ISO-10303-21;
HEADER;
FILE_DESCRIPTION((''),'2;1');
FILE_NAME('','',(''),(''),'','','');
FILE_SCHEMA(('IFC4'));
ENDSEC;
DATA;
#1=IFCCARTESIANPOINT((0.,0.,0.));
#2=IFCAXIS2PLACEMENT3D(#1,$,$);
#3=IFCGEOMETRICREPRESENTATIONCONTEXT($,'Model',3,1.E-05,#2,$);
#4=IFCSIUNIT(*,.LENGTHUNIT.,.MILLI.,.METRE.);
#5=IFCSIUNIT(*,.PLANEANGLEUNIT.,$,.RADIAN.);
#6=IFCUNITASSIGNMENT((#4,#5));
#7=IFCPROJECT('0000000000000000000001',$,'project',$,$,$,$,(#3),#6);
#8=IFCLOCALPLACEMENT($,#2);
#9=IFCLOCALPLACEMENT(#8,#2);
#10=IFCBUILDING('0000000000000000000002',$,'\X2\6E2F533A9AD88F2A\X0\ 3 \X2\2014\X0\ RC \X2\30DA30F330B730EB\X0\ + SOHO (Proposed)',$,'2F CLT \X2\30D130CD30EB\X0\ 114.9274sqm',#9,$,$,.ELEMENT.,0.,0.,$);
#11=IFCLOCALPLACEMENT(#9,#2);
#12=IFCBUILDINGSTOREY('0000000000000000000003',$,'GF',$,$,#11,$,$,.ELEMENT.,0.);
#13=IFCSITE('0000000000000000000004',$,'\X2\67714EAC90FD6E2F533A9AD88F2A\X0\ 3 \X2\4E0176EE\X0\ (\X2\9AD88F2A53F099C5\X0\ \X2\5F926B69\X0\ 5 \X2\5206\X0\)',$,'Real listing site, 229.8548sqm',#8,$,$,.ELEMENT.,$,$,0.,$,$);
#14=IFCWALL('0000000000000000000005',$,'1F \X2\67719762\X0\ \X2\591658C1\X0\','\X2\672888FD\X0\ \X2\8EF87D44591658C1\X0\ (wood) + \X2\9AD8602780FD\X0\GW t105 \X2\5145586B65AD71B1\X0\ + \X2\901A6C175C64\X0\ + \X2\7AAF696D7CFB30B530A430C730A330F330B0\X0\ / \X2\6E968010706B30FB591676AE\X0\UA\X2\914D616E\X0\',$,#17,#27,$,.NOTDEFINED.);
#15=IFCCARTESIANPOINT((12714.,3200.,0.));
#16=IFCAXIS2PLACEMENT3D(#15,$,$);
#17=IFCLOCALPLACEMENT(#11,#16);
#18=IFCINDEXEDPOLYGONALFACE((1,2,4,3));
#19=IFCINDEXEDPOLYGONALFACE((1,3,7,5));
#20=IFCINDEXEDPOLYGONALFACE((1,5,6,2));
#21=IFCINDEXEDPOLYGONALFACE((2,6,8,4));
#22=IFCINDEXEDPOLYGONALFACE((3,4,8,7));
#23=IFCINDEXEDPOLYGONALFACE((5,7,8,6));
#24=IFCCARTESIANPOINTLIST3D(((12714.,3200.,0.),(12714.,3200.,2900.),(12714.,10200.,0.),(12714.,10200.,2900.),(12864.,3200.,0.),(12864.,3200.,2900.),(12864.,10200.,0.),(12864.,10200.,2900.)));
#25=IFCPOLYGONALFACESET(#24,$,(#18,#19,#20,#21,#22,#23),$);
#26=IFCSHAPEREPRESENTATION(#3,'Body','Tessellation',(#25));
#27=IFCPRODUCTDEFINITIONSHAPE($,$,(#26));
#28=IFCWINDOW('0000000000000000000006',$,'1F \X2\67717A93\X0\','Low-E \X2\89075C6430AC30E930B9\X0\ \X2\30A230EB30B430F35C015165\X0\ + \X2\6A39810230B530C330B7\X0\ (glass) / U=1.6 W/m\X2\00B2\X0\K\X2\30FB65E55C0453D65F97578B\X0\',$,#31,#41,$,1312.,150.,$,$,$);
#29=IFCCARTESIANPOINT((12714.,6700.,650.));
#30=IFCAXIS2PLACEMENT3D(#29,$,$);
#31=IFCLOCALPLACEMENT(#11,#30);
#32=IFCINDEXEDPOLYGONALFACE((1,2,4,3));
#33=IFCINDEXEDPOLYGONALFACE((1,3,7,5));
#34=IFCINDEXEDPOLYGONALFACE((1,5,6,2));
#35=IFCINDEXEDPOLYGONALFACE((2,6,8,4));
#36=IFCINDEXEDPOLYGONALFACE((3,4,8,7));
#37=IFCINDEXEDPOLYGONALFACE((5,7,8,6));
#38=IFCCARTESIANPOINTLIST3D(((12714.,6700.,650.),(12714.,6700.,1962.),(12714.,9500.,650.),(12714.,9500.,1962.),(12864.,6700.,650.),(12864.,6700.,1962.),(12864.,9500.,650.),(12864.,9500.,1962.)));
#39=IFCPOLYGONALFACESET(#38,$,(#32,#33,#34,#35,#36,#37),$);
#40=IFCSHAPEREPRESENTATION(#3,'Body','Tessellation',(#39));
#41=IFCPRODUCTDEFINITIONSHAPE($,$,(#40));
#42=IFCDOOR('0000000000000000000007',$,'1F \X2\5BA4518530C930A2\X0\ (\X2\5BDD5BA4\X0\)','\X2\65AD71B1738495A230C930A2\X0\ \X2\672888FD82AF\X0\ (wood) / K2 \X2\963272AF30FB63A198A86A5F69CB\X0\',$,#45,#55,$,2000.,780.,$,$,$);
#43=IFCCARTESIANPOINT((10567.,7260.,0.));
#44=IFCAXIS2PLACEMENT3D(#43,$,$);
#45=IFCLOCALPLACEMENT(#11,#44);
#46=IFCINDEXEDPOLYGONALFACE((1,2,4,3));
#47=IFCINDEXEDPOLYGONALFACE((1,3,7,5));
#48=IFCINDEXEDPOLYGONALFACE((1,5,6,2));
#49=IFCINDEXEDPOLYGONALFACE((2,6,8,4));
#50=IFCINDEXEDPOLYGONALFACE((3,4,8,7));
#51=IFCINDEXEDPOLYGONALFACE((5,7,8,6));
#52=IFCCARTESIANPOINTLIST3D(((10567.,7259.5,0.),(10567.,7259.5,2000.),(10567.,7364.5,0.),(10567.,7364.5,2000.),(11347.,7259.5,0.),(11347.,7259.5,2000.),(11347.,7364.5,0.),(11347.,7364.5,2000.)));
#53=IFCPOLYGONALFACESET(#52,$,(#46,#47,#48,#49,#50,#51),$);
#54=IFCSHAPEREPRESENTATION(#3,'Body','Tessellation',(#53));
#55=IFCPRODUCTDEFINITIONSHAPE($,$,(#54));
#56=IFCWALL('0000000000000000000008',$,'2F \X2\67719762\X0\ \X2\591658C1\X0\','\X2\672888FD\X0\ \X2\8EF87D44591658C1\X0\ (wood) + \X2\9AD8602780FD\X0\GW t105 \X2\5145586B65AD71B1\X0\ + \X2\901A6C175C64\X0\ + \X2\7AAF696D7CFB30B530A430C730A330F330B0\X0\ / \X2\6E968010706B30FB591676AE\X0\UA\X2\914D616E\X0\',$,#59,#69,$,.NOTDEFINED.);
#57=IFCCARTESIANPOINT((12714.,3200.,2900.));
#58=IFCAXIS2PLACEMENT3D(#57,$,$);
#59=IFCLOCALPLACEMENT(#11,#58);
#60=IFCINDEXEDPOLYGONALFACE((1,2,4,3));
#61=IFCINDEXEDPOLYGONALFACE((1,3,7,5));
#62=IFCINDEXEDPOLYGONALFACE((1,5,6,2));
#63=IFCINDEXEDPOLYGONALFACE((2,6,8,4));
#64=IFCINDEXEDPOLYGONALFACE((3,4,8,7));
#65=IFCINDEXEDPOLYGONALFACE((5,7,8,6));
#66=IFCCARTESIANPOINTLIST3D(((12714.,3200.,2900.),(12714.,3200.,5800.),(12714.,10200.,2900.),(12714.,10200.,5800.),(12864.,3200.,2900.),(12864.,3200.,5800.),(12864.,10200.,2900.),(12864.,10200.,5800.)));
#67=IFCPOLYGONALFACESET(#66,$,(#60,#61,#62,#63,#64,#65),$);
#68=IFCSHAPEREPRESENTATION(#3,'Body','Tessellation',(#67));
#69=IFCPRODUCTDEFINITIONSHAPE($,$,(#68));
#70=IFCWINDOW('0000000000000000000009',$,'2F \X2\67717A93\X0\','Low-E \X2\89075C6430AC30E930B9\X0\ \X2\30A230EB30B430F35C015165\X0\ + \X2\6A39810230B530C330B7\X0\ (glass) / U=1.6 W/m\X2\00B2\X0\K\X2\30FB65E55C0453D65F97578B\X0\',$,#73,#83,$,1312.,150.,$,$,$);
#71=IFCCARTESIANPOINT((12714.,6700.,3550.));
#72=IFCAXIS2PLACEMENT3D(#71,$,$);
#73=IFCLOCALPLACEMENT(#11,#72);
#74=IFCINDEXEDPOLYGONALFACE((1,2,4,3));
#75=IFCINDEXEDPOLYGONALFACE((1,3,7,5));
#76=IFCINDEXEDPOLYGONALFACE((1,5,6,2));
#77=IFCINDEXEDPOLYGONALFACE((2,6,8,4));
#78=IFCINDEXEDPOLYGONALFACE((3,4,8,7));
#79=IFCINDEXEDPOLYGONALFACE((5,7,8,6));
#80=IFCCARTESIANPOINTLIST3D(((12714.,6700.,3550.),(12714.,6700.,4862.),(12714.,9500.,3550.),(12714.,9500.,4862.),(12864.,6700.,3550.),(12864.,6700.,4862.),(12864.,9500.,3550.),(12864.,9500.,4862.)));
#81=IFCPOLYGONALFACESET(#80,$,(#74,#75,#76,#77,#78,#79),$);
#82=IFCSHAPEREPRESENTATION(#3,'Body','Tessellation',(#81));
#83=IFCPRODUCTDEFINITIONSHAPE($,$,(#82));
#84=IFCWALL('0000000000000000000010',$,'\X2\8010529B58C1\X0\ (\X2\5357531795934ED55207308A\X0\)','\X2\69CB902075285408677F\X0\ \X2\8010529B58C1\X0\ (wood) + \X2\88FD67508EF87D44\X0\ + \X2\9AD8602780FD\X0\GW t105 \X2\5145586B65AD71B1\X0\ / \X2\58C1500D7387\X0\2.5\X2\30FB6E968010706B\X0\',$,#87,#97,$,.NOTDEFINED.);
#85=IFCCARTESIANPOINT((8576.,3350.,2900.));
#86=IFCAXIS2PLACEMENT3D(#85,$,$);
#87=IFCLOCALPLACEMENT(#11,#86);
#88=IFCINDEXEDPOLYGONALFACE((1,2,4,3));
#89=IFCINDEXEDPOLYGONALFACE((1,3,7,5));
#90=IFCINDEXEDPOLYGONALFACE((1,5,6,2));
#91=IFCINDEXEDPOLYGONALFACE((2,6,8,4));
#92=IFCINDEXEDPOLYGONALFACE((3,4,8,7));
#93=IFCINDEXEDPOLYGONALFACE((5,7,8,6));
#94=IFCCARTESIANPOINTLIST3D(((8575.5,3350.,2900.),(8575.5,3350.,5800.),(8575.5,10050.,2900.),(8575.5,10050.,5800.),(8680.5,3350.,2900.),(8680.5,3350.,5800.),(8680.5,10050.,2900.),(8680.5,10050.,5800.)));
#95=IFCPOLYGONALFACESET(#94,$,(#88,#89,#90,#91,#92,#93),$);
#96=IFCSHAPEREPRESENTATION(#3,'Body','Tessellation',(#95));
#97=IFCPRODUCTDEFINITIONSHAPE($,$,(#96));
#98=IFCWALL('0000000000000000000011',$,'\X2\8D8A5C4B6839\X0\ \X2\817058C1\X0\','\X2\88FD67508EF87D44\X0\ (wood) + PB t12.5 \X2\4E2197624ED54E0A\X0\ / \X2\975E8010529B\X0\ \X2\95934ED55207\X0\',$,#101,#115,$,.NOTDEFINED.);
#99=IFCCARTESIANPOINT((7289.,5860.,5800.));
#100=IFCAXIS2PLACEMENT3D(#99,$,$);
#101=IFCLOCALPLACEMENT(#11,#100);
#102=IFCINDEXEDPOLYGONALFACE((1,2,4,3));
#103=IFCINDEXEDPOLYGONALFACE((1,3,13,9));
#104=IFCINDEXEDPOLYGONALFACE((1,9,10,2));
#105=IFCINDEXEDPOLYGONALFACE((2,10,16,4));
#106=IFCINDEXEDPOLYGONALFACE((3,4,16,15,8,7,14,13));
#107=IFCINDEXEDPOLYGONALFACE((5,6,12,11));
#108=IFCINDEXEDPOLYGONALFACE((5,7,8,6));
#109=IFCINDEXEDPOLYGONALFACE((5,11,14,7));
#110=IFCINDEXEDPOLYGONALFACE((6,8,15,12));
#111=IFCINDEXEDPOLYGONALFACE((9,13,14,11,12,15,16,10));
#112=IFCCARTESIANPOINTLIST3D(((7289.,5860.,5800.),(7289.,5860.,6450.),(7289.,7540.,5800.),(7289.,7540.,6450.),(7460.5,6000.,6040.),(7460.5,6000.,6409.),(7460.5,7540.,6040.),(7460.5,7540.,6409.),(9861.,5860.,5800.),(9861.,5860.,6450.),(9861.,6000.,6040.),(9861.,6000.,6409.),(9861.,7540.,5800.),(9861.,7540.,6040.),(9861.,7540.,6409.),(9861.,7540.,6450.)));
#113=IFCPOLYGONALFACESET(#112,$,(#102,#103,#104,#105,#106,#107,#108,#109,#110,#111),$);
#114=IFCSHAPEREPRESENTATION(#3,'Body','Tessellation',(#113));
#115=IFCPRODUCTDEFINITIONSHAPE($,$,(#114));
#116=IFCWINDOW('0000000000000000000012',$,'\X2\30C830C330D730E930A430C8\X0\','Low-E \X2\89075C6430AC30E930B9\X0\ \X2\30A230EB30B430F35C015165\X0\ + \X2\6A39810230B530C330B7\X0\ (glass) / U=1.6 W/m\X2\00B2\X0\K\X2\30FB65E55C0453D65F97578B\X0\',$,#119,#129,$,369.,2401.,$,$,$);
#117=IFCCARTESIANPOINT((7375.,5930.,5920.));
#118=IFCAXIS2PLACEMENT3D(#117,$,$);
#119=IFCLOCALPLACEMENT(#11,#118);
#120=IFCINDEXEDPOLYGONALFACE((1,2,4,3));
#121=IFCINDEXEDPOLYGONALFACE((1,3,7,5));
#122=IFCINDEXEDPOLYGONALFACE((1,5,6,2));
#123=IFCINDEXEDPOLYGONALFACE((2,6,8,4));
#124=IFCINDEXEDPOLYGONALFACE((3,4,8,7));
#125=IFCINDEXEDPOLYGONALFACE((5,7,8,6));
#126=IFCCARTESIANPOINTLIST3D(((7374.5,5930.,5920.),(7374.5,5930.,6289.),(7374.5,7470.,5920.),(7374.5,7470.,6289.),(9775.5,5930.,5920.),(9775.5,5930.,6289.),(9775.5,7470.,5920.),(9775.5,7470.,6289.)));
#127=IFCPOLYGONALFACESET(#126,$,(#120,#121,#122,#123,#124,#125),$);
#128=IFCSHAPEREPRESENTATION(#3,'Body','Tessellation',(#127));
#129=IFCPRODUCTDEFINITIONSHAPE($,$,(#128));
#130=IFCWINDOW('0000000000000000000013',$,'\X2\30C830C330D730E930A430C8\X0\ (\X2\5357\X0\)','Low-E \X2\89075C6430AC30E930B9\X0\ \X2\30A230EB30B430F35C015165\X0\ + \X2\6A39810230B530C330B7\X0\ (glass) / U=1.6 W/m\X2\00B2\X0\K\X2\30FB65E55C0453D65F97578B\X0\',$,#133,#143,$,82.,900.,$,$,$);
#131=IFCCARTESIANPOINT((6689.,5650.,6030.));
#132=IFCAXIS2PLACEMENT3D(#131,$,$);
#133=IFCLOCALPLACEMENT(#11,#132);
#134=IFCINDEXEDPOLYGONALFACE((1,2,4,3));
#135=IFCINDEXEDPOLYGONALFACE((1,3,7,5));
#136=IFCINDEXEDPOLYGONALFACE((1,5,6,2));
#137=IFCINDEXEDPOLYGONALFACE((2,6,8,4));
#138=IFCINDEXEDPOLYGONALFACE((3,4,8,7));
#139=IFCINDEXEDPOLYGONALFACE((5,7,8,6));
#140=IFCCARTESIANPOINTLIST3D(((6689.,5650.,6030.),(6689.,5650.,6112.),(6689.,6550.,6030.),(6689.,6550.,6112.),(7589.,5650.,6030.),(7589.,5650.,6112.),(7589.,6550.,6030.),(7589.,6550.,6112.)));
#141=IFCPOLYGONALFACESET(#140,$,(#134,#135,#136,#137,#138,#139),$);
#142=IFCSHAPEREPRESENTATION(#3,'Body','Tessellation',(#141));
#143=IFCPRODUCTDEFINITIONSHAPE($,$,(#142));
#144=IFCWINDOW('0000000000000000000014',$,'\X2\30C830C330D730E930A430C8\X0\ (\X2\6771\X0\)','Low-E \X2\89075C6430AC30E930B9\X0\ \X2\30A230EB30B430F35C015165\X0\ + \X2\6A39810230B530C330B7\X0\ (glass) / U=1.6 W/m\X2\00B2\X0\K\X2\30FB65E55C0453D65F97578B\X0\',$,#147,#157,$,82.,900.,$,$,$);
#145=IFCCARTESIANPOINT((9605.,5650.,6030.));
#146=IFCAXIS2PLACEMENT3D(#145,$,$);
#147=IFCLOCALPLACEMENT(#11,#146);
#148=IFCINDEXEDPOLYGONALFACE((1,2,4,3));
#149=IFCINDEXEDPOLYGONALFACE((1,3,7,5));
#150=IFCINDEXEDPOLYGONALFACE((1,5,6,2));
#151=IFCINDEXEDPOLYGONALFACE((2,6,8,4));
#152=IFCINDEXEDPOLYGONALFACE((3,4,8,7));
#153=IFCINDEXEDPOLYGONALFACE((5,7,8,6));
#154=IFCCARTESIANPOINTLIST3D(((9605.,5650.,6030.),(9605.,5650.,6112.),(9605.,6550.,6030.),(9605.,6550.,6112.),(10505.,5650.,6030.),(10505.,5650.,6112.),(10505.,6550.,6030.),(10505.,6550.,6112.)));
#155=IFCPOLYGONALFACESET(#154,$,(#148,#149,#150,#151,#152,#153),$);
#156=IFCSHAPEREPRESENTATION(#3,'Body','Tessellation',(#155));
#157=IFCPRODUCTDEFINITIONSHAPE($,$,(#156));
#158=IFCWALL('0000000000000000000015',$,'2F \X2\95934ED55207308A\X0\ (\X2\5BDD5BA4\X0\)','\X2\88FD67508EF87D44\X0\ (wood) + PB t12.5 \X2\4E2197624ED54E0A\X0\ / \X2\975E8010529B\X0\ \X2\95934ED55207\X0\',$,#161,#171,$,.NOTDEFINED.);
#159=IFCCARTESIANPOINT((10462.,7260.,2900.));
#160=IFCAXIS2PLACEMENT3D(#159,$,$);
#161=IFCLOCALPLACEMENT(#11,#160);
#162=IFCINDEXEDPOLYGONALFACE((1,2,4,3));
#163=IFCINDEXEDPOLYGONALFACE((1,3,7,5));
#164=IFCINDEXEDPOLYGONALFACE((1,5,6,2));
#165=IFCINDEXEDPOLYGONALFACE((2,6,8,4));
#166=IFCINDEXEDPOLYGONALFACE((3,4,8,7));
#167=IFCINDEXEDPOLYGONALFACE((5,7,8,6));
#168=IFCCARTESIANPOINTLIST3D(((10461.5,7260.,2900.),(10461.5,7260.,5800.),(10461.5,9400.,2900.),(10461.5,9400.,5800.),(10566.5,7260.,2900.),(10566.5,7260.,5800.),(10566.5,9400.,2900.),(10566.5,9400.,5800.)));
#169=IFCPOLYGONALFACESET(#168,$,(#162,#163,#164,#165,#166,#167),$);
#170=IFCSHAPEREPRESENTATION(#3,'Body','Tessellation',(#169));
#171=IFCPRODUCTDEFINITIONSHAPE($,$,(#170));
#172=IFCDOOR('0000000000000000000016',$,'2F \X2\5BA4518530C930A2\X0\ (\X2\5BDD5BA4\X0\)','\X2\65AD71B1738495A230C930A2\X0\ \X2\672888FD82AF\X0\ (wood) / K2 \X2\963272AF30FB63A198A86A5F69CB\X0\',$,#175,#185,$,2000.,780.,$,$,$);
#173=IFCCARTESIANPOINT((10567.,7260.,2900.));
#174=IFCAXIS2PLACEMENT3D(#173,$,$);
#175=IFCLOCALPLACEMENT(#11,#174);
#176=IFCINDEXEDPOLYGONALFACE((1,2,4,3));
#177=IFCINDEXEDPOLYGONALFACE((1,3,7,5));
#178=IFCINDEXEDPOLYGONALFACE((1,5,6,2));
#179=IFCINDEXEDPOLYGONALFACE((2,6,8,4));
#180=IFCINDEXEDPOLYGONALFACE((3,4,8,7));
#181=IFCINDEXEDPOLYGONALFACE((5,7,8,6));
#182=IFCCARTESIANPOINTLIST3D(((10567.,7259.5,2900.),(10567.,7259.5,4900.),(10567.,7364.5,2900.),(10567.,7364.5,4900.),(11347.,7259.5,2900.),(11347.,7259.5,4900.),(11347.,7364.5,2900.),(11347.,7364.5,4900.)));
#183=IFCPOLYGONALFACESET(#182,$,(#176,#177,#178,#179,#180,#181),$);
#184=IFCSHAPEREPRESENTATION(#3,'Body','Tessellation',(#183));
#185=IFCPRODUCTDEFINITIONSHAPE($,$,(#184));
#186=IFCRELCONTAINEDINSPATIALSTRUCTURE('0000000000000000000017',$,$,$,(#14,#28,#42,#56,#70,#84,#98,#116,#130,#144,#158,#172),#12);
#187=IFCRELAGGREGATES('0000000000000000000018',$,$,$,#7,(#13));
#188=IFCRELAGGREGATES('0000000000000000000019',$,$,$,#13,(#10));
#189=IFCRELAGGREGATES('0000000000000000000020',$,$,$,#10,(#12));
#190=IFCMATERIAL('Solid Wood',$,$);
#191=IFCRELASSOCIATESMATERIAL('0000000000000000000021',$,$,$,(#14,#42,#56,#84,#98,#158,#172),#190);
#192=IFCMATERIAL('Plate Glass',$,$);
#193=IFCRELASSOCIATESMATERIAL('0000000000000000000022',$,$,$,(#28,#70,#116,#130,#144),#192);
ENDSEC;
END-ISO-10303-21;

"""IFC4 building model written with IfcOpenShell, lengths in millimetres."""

from ifc_helpers import new_model, si_unit, frame, frame_2d, origin, place, context, project, spatial, rectangle, extrude, material, element, fill, save


model = new_model("IFC4")

# Units and contexts
model_context = context("Model", 3, precision=1e-05, world=origin())
ifc_project = project(units=[si_unit("LENGTHUNIT", "METRE", prefix="MILLI"), si_unit("PLANEANGLEUNIT", "RADIAN")], contexts=[model_context])

# Site, building, storey
site_placement = place(None, origin())
site = spatial("IfcSite", under=ifc_project, at=site_placement, Name="東京都港区高輪 3 丁目 (高輪台駅 徒歩 5 分)", ObjectType="Real listing site, 229.8548sqm", CompositionType="ELEMENT", RefElevation=0.0)
building_placement = place(site_placement, origin())
building = spatial("IfcBuilding", under=site, at=building_placement, Name="港区高輪 3 — RC ペンシル + SOHO (Proposed)", ObjectType="2F CLT パネル 114.9274sqm", CompositionType="ELEMENT", ElevationOfRefHeight=0.0, ElevationOfTerrain=0.0)
storey_placement = place(building_placement, origin())
storey = spatial("IfcBuildingStorey", under=building, at=storey_placement, Name="GF", CompositionType="ELEMENT", Elevation=0.0)

# Wall, opening, window
ifc_material_1 = material(Name="Solid Wood")
wall_1_placement = place(storey_placement, frame((12714.0, 3200.0, 0.0)))
wall_1 = element("IfcWall", 1, at=wall_1_placement, inside=storey, material=ifc_material_1, Name="1F 東面 外壁", Description="木製 軸組外壁 (wood) + 高性能GW t105 充填断熱 + 通気層 + 窯業系サイディング / 準耐火・外皮UA配慮", PredefinedType="NOTDEFINED", context=model_context, shape_type="SweptSolid", body=[
    extrude(rectangle(XDim=150.0, YDim=7000.0, at=frame_2d((75.0, 3500.0))), frame((12714.0, 3200.0, 0.0)), (0.0, 0.0, 1.0), 2900.0),
])
opening_1_placement = place(storey_placement, frame((12714.0, 6700.0, 650.0)))
opening_1 = element("IfcOpeningElement", 2, at=opening_1_placement, cuts=wall_1, PredefinedType="NOTDEFINED", context=model_context, shape_type="SweptSolid", body=[
    extrude(rectangle(XDim=150.0, YDim=2800.0, at=frame_2d((75.0, 1400.0))), frame((12714.0, 6700.0, 650.0)), (0.0, 0.0, 1.0), 1312.0),
])
ifc_material_2 = material(Name="Plate Glass")
window_1_placement = place(storey_placement, frame((12714.0, 6700.0, 650.0)))
window_1 = element("IfcWindow", 3, at=window_1_placement, inside=storey, material=ifc_material_2, Name="1F 東窓", Description="Low-E 複層ガラス アルゴン封入 + 樹脂サッシ (glass) / U=1.6 W/m²K・日射取得型", OverallHeight=1312.0, OverallWidth=150.0, context=model_context, shape_type="SweptSolid", body=[
    extrude(rectangle(XDim=150.0, YDim=2800.0, at=frame_2d((75.0, 1400.0))), frame((12714.0, 6700.0, 650.0)), (0.0, 0.0, 1.0), 1312.0),
])
fill(opening_1, window_1)

# Door
door_1_placement = place(storey_placement, frame((10567.0, 7260.0, 0.0)))
element("IfcDoor", 4, at=door_1_placement, inside=storey, material=ifc_material_1, Name="1F 室内ドア (寝室)", Description="断熱玄関ドア 木製芯 (wood) / K2 防犯・採風機構", OverallHeight=2000.0, OverallWidth=780.0, context=model_context, shape_type="SweptSolid", body=[
    extrude(rectangle(XDim=780.0, YDim=105.0, at=frame_2d((390.0, 52.0))), frame((10567.0, 7260.0, 0.0)), (0.0, 0.0, 1.0), 2000.0),
])

# Wall, opening, window
wall_2_placement = place(storey_placement, frame((12714.0, 3200.0, 2900.0)))
wall_2 = element("IfcWall", 5, at=wall_2_placement, inside=storey, material=ifc_material_1, Name="2F 東面 外壁", Description="木製 軸組外壁 (wood) + 高性能GW t105 充填断熱 + 通気層 + 窯業系サイディング / 準耐火・外皮UA配慮", PredefinedType="NOTDEFINED", context=model_context, shape_type="SweptSolid", body=[
    extrude(rectangle(XDim=150.0, YDim=7000.0, at=frame_2d((75.0, 3500.0))), frame((12714.0, 3200.0, 2900.0)), (0.0, 0.0, 1.0), 2900.0),
])
opening_2_placement = place(storey_placement, frame((12714.0, 6700.0, 3550.0)))
opening_2 = element("IfcOpeningElement", 6, at=opening_2_placement, cuts=wall_2, PredefinedType="NOTDEFINED", context=model_context, shape_type="SweptSolid", body=[
    extrude(rectangle(XDim=150.0, YDim=2800.0, at=frame_2d((75.0, 1400.0))), frame((12714.0, 6700.0, 3550.0)), (0.0, 0.0, 1.0), 1312.0),
])
window_2_placement = place(storey_placement, frame((12714.0, 6700.0, 3550.0)))
window_2 = element("IfcWindow", 7, at=window_2_placement, inside=storey, material=ifc_material_2, Name="2F 東窓", Description="Low-E 複層ガラス アルゴン封入 + 樹脂サッシ (glass) / U=1.6 W/m²K・日射取得型", OverallHeight=1312.0, OverallWidth=150.0, context=model_context, shape_type="SweptSolid", body=[
    extrude(rectangle(XDim=150.0, YDim=2800.0, at=frame_2d((75.0, 1400.0))), frame((12714.0, 6700.0, 3550.0)), (0.0, 0.0, 1.0), 1312.0),
])
fill(opening_2, window_2)

# Wall
wall_3_placement = place(storey_placement, frame((8576.0, 3350.0, 2900.0)))
element("IfcWall", 8, at=wall_3_placement, inside=storey, material=ifc_material_1, Name="耐力壁 (南北間仕切り)", Description="構造用合板 耐力壁 (wood) + 製材軸組 + 高性能GW t105 充填断熱 / 壁倍率2.5・準耐火", PredefinedType="NOTDEFINED", context=model_context, shape_type="SweptSolid", body=[
    extrude(rectangle(XDim=105.0, YDim=6700.0, at=frame_2d((52.0, 3350.0))), frame((8576.0, 3350.0, 2900.0)), (0.0, 0.0, 1.0), 2900.0),
])

# Wall, openings, windows
wall_4_placement = place(storey_placement, frame((7289.0, 5860.0, 5800.0)))
wall_4 = element("IfcWall", 9, at=wall_4_placement, inside=storey, material=ifc_material_1, Name="越屋根 腰壁", Description="製材軸組 (wood) + PB t12.5 両面仕上 / 非耐力 間仕切", PredefinedType="NOTDEFINED", context=model_context, shape_type="SweptSolid", body=[
    extrude(rectangle(XDim=2572.0, YDim=1680.0, at=frame_2d((1286.0, 840.0))), frame((7289.0, 5860.0, 5800.0)), (0.0, 0.0, 1.0), 650.0),
])
opening_3_placement = place(storey_placement, frame((7375.0, 5930.0, 5920.0)))
opening_3 = element("IfcOpeningElement", 10, at=opening_3_placement, cuts=wall_4, PredefinedType="NOTDEFINED", context=model_context, shape_type="SweptSolid", body=[
    extrude(rectangle(XDim=2401.0, YDim=1540.0, at=frame_2d((1200.0, 770.0))), frame((7375.0, 5930.0, 5920.0)), (0.0, 0.0, 1.0), 369.0),
])
opening_4_placement = place(storey_placement, frame((6689.0, 5650.0, 6030.0)))
opening_4 = element("IfcOpeningElement", 11, at=opening_4_placement, cuts=wall_4, PredefinedType="NOTDEFINED", context=model_context, shape_type="SweptSolid", body=[
    extrude(rectangle(XDim=900.0, YDim=900.0, at=frame_2d((450.0, 450.0))), frame((6689.0, 5650.0, 6030.0)), (0.0, 0.0, 1.0), 82.0),
])
opening_5_placement = place(storey_placement, frame((9605.0, 5650.0, 6030.0)))
opening_5 = element("IfcOpeningElement", 12, at=opening_5_placement, cuts=wall_4, PredefinedType="NOTDEFINED", context=model_context, shape_type="SweptSolid", body=[
    extrude(rectangle(XDim=900.0, YDim=900.0, at=frame_2d((450.0, 450.0))), frame((9605.0, 5650.0, 6030.0)), (0.0, 0.0, 1.0), 82.0),
])
window_3_placement = place(storey_placement, frame((7375.0, 5930.0, 5920.0)))
window_3 = element("IfcWindow", 13, at=window_3_placement, inside=storey, material=ifc_material_2, Name="トップライト", Description="Low-E 複層ガラス アルゴン封入 + 樹脂サッシ (glass) / U=1.6 W/m²K・日射取得型", OverallHeight=369.0, OverallWidth=2401.0, context=model_context, shape_type="SweptSolid", body=[
    extrude(rectangle(XDim=2401.0, YDim=1540.0, at=frame_2d((1200.0, 770.0))), frame((7375.0, 5930.0, 5920.0)), (0.0, 0.0, 1.0), 369.0),
])
fill(opening_3, window_3)
window_4_placement = place(storey_placement, frame((6689.0, 5650.0, 6030.0)))
window_4 = element("IfcWindow", 14, at=window_4_placement, inside=storey, material=ifc_material_2, Name="トップライト (南)", Description="Low-E 複層ガラス アルゴン封入 + 樹脂サッシ (glass) / U=1.6 W/m²K・日射取得型", OverallHeight=82.0, OverallWidth=900.0, context=model_context, shape_type="SweptSolid", body=[
    extrude(rectangle(XDim=900.0, YDim=900.0, at=frame_2d((450.0, 450.0))), frame((6689.0, 5650.0, 6030.0)), (0.0, 0.0, 1.0), 82.0),
])
fill(opening_4, window_4)
window_5_placement = place(storey_placement, frame((9605.0, 5650.0, 6030.0)))
window_5 = element("IfcWindow", 15, at=window_5_placement, inside=storey, material=ifc_material_2, Name="トップライト (東)", Description="Low-E 複層ガラス アルゴン封入 + 樹脂サッシ (glass) / U=1.6 W/m²K・日射取得型", OverallHeight=82.0, OverallWidth=900.0, context=model_context, shape_type="SweptSolid", body=[
    extrude(rectangle(XDim=900.0, YDim=900.0, at=frame_2d((450.0, 450.0))), frame((9605.0, 5650.0, 6030.0)), (0.0, 0.0, 1.0), 82.0),
])
fill(opening_5, window_5)

# Wall
wall_5_placement = place(storey_placement, frame((10462.0, 7260.0, 2900.0)))
element("IfcWall", 16, at=wall_5_placement, inside=storey, material=ifc_material_1, Name="2F 間仕切り (寝室)", Description="製材軸組 (wood) + PB t12.5 両面仕上 / 非耐力 間仕切", PredefinedType="NOTDEFINED", context=model_context, shape_type="SweptSolid", body=[
    extrude(rectangle(XDim=105.0, YDim=2140.0, at=frame_2d((52.0, 1070.0))), frame((10462.0, 7260.0, 2900.0)), (0.0, 0.0, 1.0), 2900.0),
])

# Door
door_2_placement = place(storey_placement, frame((10567.0, 7260.0, 2900.0)))
element("IfcDoor", 17, at=door_2_placement, inside=storey, material=ifc_material_1, Name="2F 室内ドア (寝室)", Description="断熱玄関ドア 木製芯 (wood) / K2 防犯・採風機構", OverallHeight=2000.0, OverallWidth=780.0, context=model_context, shape_type="SweptSolid", body=[
    extrude(rectangle(XDim=780.0, YDim=105.0, at=frame_2d((390.0, 52.0))), frame((10567.0, 7260.0, 2900.0)), (0.0, 0.0, 1.0), 2000.0),
])

save(model, "model.ifc")
